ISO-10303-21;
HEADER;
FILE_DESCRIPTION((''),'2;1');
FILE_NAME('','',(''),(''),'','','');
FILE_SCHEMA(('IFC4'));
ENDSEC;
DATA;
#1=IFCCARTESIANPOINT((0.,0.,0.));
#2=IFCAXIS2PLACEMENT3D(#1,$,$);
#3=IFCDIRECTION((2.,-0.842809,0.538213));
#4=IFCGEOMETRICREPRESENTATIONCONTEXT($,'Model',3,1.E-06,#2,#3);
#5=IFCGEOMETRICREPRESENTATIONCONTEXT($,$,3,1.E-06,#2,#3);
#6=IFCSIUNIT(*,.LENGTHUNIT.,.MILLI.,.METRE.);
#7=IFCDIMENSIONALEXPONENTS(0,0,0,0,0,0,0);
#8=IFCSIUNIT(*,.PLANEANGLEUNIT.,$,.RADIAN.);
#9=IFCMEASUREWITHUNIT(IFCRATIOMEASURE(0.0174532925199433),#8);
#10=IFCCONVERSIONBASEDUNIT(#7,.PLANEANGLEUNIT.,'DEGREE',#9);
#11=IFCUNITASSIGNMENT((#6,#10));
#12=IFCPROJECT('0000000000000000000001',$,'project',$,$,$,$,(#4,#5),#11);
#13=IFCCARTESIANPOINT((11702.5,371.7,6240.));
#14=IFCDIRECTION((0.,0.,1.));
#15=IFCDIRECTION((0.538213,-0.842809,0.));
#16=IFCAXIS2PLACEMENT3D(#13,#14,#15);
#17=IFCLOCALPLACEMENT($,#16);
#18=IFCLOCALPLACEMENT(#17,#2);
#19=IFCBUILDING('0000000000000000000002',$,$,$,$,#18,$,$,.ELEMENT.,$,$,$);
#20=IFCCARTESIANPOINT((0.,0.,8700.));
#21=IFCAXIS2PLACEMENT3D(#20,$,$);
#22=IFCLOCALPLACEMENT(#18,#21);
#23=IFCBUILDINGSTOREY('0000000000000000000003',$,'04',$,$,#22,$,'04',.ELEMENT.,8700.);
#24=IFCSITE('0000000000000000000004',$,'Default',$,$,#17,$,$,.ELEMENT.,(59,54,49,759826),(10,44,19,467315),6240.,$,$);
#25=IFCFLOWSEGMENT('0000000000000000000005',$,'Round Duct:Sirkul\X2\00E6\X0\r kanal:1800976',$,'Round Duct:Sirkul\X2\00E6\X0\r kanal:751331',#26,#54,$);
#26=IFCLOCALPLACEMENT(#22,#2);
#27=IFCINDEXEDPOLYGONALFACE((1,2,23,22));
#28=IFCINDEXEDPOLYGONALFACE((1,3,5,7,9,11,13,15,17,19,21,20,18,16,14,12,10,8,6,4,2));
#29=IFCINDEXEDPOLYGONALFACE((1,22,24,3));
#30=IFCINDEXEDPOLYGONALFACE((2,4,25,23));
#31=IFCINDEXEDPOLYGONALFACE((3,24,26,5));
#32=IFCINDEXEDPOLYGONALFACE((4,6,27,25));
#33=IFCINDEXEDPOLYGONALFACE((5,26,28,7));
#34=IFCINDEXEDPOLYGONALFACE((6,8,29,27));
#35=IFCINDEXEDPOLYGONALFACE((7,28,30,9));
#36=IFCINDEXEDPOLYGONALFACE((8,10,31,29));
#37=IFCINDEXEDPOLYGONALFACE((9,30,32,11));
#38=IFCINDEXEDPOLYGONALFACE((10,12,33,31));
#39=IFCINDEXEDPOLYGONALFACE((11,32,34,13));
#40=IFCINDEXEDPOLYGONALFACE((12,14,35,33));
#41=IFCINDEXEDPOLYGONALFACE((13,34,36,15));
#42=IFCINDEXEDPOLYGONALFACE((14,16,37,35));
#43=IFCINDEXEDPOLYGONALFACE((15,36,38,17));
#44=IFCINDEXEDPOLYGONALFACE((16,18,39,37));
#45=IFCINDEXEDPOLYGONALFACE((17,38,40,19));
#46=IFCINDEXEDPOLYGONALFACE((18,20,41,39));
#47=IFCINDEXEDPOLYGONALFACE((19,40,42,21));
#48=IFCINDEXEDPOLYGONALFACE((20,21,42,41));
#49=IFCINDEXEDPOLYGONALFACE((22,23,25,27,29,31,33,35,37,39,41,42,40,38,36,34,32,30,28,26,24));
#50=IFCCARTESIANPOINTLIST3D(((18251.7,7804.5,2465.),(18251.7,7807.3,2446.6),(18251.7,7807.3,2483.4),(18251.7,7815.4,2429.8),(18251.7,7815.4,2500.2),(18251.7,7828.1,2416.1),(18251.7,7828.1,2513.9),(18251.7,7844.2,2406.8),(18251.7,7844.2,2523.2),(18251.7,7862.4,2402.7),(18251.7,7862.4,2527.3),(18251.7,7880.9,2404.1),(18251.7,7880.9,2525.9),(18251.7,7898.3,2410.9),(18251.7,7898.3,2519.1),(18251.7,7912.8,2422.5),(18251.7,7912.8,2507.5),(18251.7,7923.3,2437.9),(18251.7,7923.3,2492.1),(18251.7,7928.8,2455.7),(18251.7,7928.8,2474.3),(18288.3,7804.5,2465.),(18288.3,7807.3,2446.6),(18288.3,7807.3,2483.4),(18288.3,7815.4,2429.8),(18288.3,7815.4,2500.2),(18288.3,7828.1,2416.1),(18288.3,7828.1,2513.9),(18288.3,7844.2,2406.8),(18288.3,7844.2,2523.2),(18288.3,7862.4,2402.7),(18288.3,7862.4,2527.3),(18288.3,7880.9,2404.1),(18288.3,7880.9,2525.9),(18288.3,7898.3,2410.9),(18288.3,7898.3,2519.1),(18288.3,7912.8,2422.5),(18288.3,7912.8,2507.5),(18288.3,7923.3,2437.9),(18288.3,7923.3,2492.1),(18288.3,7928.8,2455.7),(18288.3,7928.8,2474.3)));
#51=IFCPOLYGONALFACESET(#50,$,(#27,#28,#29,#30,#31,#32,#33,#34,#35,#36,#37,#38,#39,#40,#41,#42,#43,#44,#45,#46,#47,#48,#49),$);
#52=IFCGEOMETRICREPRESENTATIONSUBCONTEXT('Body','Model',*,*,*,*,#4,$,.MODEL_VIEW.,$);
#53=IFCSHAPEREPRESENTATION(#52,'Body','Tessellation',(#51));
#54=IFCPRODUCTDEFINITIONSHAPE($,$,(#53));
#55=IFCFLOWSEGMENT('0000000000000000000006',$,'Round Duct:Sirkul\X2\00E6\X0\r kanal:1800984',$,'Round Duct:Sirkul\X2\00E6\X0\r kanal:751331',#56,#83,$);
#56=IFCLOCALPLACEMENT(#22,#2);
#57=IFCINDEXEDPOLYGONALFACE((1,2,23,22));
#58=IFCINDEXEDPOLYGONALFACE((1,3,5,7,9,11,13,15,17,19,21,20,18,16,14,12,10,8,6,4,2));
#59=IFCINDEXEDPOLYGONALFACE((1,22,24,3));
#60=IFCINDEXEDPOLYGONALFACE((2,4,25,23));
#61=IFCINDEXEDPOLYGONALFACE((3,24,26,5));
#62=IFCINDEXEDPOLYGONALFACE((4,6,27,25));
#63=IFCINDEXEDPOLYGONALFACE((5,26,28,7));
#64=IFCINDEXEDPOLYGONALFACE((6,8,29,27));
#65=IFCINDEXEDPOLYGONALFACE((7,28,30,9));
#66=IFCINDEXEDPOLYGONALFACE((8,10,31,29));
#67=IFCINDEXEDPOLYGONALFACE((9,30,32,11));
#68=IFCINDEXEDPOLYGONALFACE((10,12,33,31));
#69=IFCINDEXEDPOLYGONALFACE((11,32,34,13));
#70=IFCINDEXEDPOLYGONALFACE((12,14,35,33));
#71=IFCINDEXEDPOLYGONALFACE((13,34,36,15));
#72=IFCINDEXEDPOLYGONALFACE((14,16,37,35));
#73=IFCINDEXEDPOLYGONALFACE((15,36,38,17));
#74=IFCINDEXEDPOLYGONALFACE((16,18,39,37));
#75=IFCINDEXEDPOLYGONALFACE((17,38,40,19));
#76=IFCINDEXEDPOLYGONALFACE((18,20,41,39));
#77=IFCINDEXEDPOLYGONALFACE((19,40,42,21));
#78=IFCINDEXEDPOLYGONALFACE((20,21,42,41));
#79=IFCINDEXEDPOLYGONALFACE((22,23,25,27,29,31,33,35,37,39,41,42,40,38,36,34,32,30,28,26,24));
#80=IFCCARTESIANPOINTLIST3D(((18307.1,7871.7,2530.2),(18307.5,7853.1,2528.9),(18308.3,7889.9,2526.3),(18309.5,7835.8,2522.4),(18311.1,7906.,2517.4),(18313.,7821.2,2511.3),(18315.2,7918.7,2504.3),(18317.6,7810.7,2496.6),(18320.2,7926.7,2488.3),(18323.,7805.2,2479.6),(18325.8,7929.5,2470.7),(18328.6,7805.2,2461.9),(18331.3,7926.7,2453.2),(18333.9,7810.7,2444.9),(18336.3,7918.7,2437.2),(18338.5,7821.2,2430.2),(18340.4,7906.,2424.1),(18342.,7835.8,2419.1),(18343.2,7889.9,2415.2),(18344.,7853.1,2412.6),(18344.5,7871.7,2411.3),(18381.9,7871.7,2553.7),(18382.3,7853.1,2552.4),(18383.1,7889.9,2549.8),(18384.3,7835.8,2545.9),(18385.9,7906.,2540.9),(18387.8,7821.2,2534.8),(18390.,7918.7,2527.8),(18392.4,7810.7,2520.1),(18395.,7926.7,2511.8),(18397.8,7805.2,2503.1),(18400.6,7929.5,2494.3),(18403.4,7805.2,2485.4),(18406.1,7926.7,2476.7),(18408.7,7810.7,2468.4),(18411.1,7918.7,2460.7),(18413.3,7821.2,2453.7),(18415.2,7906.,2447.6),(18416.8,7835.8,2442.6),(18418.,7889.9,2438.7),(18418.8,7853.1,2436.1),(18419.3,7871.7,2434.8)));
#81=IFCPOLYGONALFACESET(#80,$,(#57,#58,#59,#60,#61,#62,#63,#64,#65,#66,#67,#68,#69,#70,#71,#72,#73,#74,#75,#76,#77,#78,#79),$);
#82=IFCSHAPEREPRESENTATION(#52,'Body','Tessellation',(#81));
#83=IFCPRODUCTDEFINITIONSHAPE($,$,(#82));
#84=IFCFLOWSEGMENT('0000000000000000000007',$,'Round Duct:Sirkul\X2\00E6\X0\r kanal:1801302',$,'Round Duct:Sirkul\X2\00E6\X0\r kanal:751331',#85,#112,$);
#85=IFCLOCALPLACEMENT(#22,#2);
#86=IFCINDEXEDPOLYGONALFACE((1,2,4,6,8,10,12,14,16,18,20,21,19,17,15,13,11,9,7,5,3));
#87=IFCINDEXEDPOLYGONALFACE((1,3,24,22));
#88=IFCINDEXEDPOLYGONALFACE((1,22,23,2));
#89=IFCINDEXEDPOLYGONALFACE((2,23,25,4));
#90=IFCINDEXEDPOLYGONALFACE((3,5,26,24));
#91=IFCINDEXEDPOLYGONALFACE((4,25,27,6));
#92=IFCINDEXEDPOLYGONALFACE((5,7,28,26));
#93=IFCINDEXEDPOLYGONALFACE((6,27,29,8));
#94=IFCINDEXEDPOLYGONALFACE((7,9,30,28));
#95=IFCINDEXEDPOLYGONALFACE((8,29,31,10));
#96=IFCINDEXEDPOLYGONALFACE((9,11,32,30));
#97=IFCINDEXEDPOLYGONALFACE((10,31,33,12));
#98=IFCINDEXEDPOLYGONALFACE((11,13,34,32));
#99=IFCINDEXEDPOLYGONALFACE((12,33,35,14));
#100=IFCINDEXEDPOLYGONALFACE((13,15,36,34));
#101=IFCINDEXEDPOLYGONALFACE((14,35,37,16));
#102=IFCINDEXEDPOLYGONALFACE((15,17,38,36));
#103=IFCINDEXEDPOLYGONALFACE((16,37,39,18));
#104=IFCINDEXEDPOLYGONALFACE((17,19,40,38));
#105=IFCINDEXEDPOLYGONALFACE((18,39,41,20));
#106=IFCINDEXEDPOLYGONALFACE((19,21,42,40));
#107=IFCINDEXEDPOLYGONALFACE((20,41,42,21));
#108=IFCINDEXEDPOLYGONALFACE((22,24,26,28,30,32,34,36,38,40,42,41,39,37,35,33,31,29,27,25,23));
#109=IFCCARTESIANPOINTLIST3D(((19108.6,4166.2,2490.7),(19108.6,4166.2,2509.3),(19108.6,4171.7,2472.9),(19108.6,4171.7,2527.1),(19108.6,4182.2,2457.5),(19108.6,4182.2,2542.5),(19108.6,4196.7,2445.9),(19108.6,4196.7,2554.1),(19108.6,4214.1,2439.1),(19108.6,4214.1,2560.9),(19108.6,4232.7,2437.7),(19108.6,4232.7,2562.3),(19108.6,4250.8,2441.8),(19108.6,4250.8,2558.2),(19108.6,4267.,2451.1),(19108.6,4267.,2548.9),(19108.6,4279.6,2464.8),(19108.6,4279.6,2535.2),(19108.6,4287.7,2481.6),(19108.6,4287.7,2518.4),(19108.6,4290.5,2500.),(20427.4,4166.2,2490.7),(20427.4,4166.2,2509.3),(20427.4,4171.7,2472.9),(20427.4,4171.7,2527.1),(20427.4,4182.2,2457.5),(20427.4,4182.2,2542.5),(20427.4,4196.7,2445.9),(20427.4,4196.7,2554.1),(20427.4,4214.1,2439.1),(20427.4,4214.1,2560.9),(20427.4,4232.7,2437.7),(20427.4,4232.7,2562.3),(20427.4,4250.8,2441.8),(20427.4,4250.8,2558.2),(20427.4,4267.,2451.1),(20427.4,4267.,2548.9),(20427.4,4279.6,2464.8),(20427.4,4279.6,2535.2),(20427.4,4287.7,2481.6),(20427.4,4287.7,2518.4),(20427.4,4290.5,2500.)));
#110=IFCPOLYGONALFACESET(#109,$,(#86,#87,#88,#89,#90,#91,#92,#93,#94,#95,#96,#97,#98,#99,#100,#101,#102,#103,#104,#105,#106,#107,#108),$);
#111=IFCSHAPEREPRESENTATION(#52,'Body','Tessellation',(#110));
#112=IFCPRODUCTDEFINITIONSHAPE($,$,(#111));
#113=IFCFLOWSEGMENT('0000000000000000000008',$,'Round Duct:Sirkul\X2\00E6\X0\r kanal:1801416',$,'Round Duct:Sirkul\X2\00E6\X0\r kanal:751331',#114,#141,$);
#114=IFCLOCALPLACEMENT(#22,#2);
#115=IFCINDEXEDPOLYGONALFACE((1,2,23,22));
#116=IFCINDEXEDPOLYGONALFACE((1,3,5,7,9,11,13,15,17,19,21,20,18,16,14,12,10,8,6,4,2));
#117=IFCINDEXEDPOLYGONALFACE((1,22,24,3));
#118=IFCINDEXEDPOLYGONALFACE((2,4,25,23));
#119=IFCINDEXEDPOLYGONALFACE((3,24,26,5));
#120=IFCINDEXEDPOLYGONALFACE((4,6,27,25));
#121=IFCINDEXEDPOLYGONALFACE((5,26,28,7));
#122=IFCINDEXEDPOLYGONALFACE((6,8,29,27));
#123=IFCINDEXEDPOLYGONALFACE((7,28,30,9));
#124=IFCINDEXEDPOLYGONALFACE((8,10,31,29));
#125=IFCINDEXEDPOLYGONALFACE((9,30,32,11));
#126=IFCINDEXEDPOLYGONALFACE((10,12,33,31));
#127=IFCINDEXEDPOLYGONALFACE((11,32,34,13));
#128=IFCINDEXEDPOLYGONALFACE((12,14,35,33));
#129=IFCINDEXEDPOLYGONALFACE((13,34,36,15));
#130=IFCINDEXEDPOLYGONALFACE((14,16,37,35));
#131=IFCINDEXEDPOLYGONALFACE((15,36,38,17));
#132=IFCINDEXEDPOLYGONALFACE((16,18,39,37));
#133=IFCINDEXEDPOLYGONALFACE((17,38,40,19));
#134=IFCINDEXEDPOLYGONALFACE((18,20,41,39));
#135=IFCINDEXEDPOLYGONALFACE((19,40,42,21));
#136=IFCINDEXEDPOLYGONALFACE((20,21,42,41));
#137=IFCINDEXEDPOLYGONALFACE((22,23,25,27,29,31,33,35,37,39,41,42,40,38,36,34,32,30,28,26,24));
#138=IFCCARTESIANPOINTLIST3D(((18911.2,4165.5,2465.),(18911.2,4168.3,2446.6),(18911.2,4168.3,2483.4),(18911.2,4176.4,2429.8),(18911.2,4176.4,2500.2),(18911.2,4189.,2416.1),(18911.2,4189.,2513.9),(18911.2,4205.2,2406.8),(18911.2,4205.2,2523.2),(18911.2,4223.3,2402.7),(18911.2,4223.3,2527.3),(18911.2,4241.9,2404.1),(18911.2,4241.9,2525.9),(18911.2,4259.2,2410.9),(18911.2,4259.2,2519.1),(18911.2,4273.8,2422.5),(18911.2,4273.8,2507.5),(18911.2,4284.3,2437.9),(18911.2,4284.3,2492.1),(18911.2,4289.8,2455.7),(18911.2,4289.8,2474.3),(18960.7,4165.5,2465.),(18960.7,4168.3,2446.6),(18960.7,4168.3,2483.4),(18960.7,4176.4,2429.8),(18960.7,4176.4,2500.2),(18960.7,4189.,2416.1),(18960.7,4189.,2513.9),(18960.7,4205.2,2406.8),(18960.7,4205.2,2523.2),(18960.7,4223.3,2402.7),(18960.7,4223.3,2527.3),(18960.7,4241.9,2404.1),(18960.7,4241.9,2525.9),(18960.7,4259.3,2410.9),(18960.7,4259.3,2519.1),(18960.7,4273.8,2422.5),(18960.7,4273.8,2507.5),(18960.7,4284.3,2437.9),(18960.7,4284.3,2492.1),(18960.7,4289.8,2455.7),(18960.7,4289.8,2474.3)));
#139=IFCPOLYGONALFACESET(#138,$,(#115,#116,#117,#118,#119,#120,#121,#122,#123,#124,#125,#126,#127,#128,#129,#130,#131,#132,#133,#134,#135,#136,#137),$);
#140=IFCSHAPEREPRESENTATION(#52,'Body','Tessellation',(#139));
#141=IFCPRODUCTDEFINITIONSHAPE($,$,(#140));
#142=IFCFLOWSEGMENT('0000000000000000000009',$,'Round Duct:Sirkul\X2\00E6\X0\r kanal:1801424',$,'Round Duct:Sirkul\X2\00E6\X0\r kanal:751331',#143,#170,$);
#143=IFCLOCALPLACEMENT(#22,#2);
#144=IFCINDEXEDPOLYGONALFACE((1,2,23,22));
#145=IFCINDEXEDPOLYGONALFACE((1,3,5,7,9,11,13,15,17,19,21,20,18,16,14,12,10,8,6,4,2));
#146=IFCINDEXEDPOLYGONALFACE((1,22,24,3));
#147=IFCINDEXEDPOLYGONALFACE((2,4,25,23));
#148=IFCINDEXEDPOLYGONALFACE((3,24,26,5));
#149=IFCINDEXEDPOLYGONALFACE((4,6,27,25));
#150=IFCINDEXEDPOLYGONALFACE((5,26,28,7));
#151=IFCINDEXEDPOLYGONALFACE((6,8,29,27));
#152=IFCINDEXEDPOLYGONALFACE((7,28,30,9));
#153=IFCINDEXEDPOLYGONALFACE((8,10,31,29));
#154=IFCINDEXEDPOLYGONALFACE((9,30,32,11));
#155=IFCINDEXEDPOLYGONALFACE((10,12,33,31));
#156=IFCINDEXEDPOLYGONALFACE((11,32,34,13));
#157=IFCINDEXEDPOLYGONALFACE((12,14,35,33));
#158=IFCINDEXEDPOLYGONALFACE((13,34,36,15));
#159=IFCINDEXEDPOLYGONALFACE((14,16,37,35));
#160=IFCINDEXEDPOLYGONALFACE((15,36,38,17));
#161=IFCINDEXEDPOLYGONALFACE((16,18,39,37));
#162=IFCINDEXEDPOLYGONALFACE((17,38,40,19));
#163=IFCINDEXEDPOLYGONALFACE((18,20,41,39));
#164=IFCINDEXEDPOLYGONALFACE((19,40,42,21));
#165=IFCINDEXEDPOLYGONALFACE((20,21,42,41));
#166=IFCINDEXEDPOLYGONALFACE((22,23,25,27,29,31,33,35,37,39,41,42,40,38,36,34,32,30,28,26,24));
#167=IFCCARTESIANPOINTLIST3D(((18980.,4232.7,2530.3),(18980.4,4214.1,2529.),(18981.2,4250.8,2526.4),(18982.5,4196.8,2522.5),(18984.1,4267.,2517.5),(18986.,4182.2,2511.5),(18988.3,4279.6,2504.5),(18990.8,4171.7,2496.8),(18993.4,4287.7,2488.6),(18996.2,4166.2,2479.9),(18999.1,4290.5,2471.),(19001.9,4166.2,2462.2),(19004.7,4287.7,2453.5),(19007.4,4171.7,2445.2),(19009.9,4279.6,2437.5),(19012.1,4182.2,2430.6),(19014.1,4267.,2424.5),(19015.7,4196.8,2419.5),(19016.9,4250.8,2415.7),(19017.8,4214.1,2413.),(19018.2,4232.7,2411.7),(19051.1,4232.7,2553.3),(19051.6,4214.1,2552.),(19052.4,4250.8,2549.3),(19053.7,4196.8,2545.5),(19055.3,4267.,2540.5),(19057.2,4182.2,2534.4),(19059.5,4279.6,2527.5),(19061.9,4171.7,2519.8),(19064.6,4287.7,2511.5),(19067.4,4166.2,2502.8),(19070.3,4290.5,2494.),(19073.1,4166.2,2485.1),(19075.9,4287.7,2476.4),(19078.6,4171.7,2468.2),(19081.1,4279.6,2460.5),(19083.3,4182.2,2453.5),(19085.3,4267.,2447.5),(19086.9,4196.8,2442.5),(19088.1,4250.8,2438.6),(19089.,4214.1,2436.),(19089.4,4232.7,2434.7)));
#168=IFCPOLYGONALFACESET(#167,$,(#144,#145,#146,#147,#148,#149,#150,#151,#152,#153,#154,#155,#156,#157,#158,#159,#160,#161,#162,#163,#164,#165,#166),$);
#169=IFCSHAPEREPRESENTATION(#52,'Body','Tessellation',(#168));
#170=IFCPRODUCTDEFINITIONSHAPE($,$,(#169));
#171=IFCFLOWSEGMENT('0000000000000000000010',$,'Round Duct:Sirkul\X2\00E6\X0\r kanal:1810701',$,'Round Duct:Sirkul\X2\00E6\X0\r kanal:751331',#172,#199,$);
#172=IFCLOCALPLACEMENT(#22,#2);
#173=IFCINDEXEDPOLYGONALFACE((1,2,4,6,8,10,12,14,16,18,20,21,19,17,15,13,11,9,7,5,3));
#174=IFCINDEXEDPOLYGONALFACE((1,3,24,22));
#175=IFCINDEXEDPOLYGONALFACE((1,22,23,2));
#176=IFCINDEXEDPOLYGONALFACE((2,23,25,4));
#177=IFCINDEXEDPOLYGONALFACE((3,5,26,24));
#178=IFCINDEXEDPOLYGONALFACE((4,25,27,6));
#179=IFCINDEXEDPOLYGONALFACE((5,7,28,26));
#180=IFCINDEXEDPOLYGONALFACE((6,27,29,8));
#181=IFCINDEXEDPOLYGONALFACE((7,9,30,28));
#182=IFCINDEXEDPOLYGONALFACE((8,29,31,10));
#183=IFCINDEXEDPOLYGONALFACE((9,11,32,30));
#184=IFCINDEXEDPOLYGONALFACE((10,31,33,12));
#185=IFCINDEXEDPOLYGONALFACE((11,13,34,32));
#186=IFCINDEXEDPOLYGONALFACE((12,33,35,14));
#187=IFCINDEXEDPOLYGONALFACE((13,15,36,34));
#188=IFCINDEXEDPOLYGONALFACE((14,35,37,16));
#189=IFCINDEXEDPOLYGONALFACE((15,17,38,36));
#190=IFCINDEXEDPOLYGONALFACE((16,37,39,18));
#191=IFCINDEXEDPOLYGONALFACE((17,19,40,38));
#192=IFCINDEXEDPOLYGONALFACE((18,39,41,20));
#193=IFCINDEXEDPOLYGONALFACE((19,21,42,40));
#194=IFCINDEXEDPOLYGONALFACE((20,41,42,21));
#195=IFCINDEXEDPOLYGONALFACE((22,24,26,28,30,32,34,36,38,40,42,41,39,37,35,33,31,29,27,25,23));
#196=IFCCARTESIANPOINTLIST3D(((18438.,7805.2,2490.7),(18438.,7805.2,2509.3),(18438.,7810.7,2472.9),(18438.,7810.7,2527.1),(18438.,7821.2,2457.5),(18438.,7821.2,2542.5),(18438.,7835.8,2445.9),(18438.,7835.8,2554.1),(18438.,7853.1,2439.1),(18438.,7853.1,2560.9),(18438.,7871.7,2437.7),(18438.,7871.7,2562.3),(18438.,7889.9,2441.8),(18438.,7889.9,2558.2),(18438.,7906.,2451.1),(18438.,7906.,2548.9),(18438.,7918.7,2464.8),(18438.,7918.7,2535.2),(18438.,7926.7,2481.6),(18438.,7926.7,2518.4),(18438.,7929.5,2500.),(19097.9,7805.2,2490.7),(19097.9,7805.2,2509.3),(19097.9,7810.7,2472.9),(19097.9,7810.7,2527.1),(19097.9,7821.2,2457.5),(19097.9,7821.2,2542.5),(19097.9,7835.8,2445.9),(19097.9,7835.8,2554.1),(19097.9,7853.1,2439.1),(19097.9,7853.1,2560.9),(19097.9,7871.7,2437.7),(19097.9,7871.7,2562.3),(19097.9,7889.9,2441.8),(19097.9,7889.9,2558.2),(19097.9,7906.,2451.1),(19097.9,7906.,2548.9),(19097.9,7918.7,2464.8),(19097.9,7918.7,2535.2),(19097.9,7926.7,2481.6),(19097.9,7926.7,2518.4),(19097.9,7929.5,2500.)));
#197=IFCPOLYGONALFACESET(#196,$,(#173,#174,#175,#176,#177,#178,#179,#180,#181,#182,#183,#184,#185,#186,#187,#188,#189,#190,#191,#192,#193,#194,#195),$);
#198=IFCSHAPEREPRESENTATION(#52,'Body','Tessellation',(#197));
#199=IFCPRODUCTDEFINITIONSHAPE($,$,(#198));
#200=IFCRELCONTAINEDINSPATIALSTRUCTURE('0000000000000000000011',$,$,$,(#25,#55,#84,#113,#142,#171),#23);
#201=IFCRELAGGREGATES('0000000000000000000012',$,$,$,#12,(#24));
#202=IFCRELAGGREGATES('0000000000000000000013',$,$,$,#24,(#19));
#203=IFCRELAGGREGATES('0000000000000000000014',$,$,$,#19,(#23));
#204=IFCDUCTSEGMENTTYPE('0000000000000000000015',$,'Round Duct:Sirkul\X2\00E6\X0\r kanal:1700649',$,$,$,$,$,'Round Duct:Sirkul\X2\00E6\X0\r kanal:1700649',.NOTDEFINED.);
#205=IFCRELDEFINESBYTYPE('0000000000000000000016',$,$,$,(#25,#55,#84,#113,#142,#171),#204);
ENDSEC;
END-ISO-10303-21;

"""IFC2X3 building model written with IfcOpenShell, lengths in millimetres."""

from ifc_helpers import new_model, entity, si_unit, converted_unit, direction, frame, frame_2d, origin, place, context, subcontext, project, spatial, circle, extrude, type_object, element, save


model = new_model("IFC2X3")

# Units and contexts
model_context = context("Model", 3, precision=1e-06, world=origin(), true_north=direction((2.0, -0.842809, 0.538213)))
context_of_model = context(None, 3, precision=1e-06, world=origin(), true_north=direction((2.0, -0.842809, 0.538213)))
body_context = subcontext(model_context, "Body", "Model", "MODEL_VIEW")
ifc_project = project(units=[si_unit("LENGTHUNIT", "METRE", prefix="MILLI"), converted_unit("PLANEANGLEUNIT", "DEGREE", entity("IfcRatioMeasure", 0.0174532925199433), si_unit("PLANEANGLEUNIT", "RADIAN"), dimensions=[0, 0, 0, 0, 0, 0, 0])], contexts=[model_context, context_of_model])

# Site, building, storey
site_placement = place(None, frame((11702.5, 371.7, 6240.0), z_axis=(0.0, 0.0, 1.0), x_axis=(0.538213, -0.842809, 0.0)))
site = spatial("IfcSite", under=ifc_project, at=site_placement, Name="Default", CompositionType="ELEMENT", RefLatitude=(59, 54, 49, 759826), RefLongitude=(10, 44, 19, 467315), RefElevation=6240.0)
building_placement = place(site_placement, origin())
building = spatial("IfcBuilding", under=site, at=building_placement, CompositionType="ELEMENT")
storey_placement = place(building_placement, frame((0.0, 0.0, 8700.0)))
storey = spatial("IfcBuildingStorey", under=building, at=storey_placement, Name="04", LongName="04", CompositionType="ELEMENT", Elevation=8700.0)

# Flow segments
duct_segment_type_1 = type_object("IfcDuctSegmentType", Name="Round Duct:Sirkulær kanal:1700649", ElementType="Round Duct:Sirkulær kanal:1700649", PredefinedType="NOTDEFINED")
flow_segment_1_placement = place(storey_placement, origin())
element("IfcFlowSegment", 1, at=flow_segment_1_placement, inside=storey, type_object=duct_segment_type_1, Name="Round Duct:Sirkulær kanal:1800976", ObjectType="Round Duct:Sirkulær kanal:751331", context=body_context, shape_type="SweptSolid", body=[
    extrude(circle(Radius=62.5, at=frame_2d((0.0, 0.0), x_axis=(1.0, 0.0))), frame((18251.7, 7867.0, 2465.0), z_axis=(1.0, 0.0, 0.0), x_axis=(0.0, -1.0, 0.0)), (0.0, 0.0, 1.0), 36.6),
])
flow_segment_2_placement = place(storey_placement, origin())
element("IfcFlowSegment", 2, at=flow_segment_2_placement, inside=storey, type_object=duct_segment_type_1, Name="Round Duct:Sirkulær kanal:1800984", ObjectType="Round Duct:Sirkulær kanal:751331", context=body_context, shape_type="SweptSolid", body=[
    extrude(circle(Radius=62.5, at=frame_2d((0.0, 0.0), x_axis=(1.0, 0.0))), frame((18325.8, 7867.0, 2470.7), z_axis=(0.954011, 0.0, 0.29977), x_axis=(0.0, 1.0, 0.0)), (0.0, 0.0, 1.0), 78.4),
])
flow_segment_3_placement = place(storey_placement, origin())
element("IfcFlowSegment", 3, at=flow_segment_3_placement, inside=storey, type_object=duct_segment_type_1, Name="Round Duct:Sirkulær kanal:1801302", ObjectType="Round Duct:Sirkulær kanal:751331", context=body_context, shape_type="SweptSolid", body=[
    extrude(circle(Radius=62.5, at=frame_2d((0.0, 0.0), x_axis=(1.0, 0.0))), frame((19108.6, 4228.0, 2500.0), z_axis=(1.0, 0.0, 0.0), x_axis=(0.0, 1.0, 0.0)), (0.0, 0.0, 1.0), 1318.7),
])
flow_segment_4_placement = place(storey_placement, origin())
element("IfcFlowSegment", 4, at=flow_segment_4_placement, inside=storey, type_object=duct_segment_type_1, Name="Round Duct:Sirkulær kanal:1801416", ObjectType="Round Duct:Sirkulær kanal:751331", context=body_context, shape_type="SweptSolid", body=[
    extrude(circle(Radius=62.5, at=frame_2d((0.0, 0.0), x_axis=(1.0, 0.0))), frame((18911.2, 4228.0, 2465.0), z_axis=(1.0, 0.0, 0.0), x_axis=(0.0, -1.0, 0.0)), (0.0, 0.0, 1.0), 49.5),
])
flow_segment_5_placement = place(storey_placement, origin())
element("IfcFlowSegment", 5, at=flow_segment_5_placement, inside=storey, type_object=duct_segment_type_1, Name="Round Duct:Sirkulær kanal:1801424", ObjectType="Round Duct:Sirkulær kanal:751331", context=body_context, shape_type="SweptSolid", body=[
    extrude(circle(Radius=62.5, at=frame_2d((0.0, 0.0), x_axis=(1.0, 0.0))), frame((18999.1, 4228.0, 2471.0), z_axis=(0.951777, 0.0, 0.306792), x_axis=(0.0, 1.0, 0.0)), (0.0, 0.0, 1.0), 74.8),
])
flow_segment_6_placement = place(storey_placement, origin())
element("IfcFlowSegment", 6, at=flow_segment_6_placement, inside=storey, type_object=duct_segment_type_1, Name="Round Duct:Sirkulær kanal:1810701", ObjectType="Round Duct:Sirkulær kanal:751331", context=body_context, shape_type="SweptSolid", body=[
    extrude(circle(Radius=62.5, at=frame_2d((0.0, 0.0), x_axis=(1.0, 0.0))), frame((18438.0, 7867.0, 2500.0), z_axis=(1.0, 0.0, 0.0), x_axis=(0.0, 1.0, 0.0)), (0.0, 0.0, 1.0), 659.9),
])

save(model, "model.ifc")
